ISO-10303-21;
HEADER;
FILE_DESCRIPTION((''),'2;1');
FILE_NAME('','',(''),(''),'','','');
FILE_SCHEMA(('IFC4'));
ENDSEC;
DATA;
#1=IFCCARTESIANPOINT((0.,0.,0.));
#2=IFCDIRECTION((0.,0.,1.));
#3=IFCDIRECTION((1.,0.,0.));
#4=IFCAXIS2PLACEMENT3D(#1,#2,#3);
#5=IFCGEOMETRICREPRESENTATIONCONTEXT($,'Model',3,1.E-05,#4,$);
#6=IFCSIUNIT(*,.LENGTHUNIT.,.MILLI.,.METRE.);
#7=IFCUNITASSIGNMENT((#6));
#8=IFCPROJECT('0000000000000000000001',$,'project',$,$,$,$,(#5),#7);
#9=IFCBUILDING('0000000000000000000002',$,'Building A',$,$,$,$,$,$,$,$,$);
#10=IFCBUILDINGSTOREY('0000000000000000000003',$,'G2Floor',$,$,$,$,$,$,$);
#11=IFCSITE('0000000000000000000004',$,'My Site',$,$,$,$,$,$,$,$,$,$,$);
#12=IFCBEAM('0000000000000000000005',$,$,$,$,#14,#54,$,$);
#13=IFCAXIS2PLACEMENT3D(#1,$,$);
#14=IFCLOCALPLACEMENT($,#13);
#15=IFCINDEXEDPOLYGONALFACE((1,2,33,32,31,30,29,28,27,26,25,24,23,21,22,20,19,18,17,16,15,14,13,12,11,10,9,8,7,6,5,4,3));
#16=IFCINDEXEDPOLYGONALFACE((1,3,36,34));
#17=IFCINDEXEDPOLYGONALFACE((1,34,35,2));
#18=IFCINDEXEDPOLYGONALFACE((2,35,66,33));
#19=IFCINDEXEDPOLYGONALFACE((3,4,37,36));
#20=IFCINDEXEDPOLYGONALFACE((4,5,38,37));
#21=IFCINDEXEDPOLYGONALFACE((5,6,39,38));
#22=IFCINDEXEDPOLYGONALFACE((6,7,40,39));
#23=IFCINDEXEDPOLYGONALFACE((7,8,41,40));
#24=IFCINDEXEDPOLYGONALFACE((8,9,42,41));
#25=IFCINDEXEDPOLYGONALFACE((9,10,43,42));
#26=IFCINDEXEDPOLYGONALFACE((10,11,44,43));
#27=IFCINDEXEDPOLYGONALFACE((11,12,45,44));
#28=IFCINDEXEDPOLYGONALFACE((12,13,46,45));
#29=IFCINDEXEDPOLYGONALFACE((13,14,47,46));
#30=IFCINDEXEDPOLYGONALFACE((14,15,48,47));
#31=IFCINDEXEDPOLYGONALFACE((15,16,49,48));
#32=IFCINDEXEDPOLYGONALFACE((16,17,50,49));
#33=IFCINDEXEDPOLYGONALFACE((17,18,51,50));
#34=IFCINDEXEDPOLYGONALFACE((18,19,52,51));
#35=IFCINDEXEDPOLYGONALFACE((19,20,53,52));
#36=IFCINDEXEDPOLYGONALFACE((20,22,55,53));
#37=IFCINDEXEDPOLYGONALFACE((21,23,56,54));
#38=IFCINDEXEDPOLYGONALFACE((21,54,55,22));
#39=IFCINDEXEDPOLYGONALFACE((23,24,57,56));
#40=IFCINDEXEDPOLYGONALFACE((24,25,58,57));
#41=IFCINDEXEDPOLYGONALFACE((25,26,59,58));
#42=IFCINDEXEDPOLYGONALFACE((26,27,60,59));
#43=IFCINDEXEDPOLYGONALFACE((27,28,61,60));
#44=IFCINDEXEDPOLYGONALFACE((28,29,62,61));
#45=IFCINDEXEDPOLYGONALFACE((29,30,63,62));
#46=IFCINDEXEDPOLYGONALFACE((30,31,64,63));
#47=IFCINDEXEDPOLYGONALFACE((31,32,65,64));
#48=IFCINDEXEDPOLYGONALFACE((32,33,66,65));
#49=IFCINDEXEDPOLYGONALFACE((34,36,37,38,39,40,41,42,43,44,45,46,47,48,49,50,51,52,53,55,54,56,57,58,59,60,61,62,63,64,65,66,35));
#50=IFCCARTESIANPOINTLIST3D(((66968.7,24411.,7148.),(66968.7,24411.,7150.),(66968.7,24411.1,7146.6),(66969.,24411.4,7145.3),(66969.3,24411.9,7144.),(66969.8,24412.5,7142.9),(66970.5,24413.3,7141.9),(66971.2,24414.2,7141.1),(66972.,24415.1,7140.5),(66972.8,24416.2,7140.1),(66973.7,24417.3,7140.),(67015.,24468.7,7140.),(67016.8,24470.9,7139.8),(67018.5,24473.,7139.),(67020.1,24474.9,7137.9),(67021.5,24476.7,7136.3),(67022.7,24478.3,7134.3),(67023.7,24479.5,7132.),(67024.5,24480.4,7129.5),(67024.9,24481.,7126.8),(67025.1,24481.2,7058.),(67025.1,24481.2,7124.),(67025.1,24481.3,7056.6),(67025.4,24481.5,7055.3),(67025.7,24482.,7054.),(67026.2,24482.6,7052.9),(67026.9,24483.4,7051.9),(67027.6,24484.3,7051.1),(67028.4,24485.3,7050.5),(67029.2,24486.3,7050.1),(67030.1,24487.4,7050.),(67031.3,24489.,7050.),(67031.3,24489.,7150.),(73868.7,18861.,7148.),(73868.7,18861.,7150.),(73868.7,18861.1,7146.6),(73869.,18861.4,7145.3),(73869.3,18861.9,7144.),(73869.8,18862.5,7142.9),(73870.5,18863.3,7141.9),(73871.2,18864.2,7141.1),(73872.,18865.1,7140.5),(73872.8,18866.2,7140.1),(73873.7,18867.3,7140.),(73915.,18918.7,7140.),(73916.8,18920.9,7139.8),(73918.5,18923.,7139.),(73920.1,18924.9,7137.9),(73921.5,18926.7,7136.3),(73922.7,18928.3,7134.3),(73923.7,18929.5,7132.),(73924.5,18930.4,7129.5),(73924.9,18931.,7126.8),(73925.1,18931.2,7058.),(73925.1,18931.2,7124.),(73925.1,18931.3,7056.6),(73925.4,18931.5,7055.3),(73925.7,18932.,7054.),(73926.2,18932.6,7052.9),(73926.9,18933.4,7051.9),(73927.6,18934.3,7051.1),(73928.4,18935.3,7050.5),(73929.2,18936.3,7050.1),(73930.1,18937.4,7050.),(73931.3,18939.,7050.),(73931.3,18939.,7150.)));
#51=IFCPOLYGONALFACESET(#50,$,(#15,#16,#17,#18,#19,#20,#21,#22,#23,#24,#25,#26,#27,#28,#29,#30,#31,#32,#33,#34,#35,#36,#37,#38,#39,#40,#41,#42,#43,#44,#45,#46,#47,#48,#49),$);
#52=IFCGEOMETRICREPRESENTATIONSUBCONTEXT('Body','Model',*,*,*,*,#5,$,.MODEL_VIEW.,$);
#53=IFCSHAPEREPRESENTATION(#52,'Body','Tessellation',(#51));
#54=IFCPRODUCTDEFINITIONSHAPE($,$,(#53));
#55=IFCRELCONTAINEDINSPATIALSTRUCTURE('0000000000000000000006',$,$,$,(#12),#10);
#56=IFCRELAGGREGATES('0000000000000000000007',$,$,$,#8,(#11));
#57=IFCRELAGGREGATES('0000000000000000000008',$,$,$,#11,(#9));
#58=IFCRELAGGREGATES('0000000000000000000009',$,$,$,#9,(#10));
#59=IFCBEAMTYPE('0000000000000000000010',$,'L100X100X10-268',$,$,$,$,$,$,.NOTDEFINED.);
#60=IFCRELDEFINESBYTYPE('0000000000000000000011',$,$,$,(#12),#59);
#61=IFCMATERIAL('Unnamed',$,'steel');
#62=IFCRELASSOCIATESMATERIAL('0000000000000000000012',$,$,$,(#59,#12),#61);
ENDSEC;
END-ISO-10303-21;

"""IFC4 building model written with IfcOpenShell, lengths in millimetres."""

from ifc_helpers import new_model, si_unit, frame, origin_with_axes, place, context, subcontext, project, spatial, polyline, outline, extrude, material, material_profile, profile_set, profile_usage, type_object, element, save


model = new_model("IFC4")

# Units and contexts
model_context = context("Model", 3, precision=1e-05, world=origin_with_axes())
body_context = subcontext(model_context, "Body", "Model", "MODEL_VIEW")
ifc_project = project(units=[si_unit("LENGTHUNIT", "METRE", prefix="MILLI")], contexts=[model_context])

# Site, building, storey
site = spatial("IfcSite", under=ifc_project, Name="My Site")
building = spatial("IfcBuilding", under=site, Name="Building A")
storey = spatial("IfcBuildingStorey", under=building, Name="G2Floor")

# Beam
ifc_material_1 = material(Name="Unnamed", Category="steel")
ifc_material_profile_1 = material_profile(ifc_material_1, outline(polyline([(-50.0, -50.0), (50.0, -50.0), (50.0, -50.0), (50.0, -48.0), (50.0, -48.0), (49.9, -46.6), (49.9, -46.6), (49.5, -45.3), (49.5, -45.3), (48.9, -44.0), (48.9, -44.0), (48.1, -42.9), (48.1, -42.9), (47.1, -41.9), (47.1, -41.9), (46.0, -41.1), (46.0, -41.1), (44.7, -40.5), (44.7, -40.5), (43.4, -40.1), (43.4, -40.1), (42.0, -40.0), (42.0, -40.0), (-24.0, -40.0), (-24.0, -40.0), (-26.8, -39.8), (-26.8, -39.8), (-29.5, -39.0), (-29.5, -39.0), (-32.0, -37.9), (-32.0, -37.9), (-34.3, -36.3), (-34.3, -36.3), (-36.3, -34.3), (-36.3, -34.3), (-37.9, -32.0), (-37.9, -32.0), (-39.0, -29.5), (-39.0, -29.5), (-39.8, -26.8), (-39.8, -26.8), (-40.0, -24.0), (-40.0, -24.0), (-40.0, 42.0), (-40.0, 42.0), (-40.1, 43.4), (-40.1, 43.4), (-40.5, 44.7), (-40.5, 44.7), (-41.1, 46.0), (-41.1, 46.0), (-41.9, 47.1), (-41.9, 47.1), (-42.9, 48.1), (-42.9, 48.1), (-44.0, 48.9), (-44.0, 48.9), (-45.3, 49.5), (-45.3, 49.5), (-46.6, 49.9), (-46.6, 49.9), (-48.0, 50.0), (-48.0, 50.0), (-50.0, 50.0), (-50.0, 50.0), (-50.0, -50.0)])))
ifc_profile_set_1 = profile_set([ifc_material_profile_1], Name="L100X100X10-268")
ifc_profile_usage_1 = profile_usage(ifc_profile_set_1)
beam_type_1 = type_object("IfcBeamType", Name="L100X100X10-268", PredefinedType="NOTDEFINED", material=ifc_profile_set_1)
beam_1_placement = place(None, frame((67000.0, 24450.0, 7100.0), z_axis=(0.779213, -0.626759, 0.0), x_axis=(-0.626759, -0.779213, 0.0)))
element("IfcBeam", 1, at=beam_1_placement, inside=storey, type_object=beam_type_1, material=ifc_profile_usage_1, context=body_context, shape_type="SweptSolid", body=[
    extrude(outline(polyline([(-50.0, -50.0), (50.0, -50.0), (50.0, -50.0), (50.0, -48.0), (50.0, -48.0), (49.9, -46.6), (49.9, -46.6), (49.5, -45.3), (49.5, -45.3), (48.9, -44.0), (48.9, -44.0), (48.1, -42.9), (48.1, -42.9), (47.1, -41.9), (47.1, -41.9), (46.0, -41.1), (46.0, -41.1), (44.7, -40.5), (44.7, -40.5), (43.4, -40.1), (43.4, -40.1), (42.0, -40.0), (42.0, -40.0), (-24.0, -40.0), (-24.0, -40.0), (-26.8, -39.8), (-26.8, -39.8), (-29.5, -39.0), (-29.5, -39.0), (-32.0, -37.9), (-32.0, -37.9), (-34.3, -36.3), (-34.3, -36.3), (-36.3, -34.3), (-36.3, -34.3), (-37.9, -32.0), (-37.9, -32.0), (-39.0, -29.5), (-39.0, -29.5), (-39.8, -26.8), (-39.8, -26.8), (-40.0, -24.0), (-40.0, -24.0), (-40.0, 42.0), (-40.0, 42.0), (-40.1, 43.4), (-40.1, 43.4), (-40.5, 44.7), (-40.5, 44.7), (-41.1, 46.0), (-41.1, 46.0), (-41.9, 47.1), (-41.9, 47.1), (-42.9, 48.1), (-42.9, 48.1), (-44.0, 48.9), (-44.0, 48.9), (-45.3, 49.5), (-45.3, 49.5), (-46.6, 49.9), (-46.6, 49.9), (-48.0, 50.0), (-48.0, 50.0), (-50.0, 50.0), (-50.0, 50.0), (-50.0, -50.0)])), origin_with_axes(), (0.0, 0.0, 1.0), 8855.1),
])

save(model, "model.ifc")
